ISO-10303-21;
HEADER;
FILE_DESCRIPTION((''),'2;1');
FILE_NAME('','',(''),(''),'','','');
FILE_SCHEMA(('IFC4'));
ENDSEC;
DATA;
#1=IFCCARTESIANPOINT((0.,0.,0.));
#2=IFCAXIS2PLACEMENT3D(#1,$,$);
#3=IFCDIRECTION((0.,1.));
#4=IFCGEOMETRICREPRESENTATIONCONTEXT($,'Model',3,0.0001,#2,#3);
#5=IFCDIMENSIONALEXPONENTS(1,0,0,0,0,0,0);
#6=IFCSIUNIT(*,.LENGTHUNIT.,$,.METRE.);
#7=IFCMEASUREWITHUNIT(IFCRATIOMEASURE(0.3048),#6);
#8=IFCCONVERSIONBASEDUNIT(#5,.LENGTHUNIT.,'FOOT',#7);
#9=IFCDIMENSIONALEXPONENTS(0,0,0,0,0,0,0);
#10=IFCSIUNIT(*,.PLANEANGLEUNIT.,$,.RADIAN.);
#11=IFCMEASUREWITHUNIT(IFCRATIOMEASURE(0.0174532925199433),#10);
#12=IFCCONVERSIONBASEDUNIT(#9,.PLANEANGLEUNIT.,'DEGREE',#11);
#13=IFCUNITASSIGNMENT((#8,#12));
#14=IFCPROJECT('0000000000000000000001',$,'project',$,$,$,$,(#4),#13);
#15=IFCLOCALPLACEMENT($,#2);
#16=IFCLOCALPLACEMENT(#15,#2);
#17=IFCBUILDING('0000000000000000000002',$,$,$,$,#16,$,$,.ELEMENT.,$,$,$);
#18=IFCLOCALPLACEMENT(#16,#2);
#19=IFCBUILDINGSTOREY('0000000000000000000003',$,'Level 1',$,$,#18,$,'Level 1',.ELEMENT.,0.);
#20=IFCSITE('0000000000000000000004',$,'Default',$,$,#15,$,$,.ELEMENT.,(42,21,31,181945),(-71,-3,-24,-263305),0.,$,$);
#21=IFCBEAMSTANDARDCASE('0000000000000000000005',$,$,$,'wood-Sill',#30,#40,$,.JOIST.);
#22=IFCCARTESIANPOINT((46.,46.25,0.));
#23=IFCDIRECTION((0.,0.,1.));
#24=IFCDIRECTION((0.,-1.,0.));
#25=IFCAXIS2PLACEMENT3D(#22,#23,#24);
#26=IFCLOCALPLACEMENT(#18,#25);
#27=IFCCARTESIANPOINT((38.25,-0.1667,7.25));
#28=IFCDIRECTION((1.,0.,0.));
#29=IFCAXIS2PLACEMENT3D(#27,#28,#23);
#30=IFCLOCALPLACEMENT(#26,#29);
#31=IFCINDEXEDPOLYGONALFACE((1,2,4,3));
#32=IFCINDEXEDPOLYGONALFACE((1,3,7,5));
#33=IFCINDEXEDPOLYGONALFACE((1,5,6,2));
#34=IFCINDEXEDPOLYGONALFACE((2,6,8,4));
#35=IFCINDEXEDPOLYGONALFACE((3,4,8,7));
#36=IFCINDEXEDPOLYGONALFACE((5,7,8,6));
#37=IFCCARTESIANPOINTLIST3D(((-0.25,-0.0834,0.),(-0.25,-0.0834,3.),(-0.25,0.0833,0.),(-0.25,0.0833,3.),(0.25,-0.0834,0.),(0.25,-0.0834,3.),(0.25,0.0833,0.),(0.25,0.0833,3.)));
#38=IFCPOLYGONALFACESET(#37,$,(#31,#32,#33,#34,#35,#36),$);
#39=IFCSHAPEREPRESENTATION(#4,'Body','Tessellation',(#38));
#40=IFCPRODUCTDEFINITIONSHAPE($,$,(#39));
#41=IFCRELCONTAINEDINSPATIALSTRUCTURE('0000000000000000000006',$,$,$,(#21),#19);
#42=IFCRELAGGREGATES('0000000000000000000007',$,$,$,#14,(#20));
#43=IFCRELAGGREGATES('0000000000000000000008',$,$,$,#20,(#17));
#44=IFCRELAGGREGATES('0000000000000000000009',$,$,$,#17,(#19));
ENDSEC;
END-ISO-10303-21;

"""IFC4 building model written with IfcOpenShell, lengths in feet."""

from ifc_helpers import new_model, entity, si_unit, converted_unit, direction, frame, origin, origin_with_axes, place, context, project, spatial, rectangle, extrude, element, save


model = new_model("IFC4")

# Units and contexts
model_context = context("Model", 3, precision=0.0001, world=origin(), true_north=direction((0.0, 1.0)))
ifc_project = project(units=[converted_unit("LENGTHUNIT", "FOOT", entity("IfcRatioMeasure", 0.3048), si_unit("LENGTHUNIT", "METRE"), dimensions=[1, 0, 0, 0, 0, 0, 0]), converted_unit("PLANEANGLEUNIT", "DEGREE", entity("IfcRatioMeasure", 0.0174532925199433), si_unit("PLANEANGLEUNIT", "RADIAN"), dimensions=[0, 0, 0, 0, 0, 0, 0])], contexts=[model_context])

# Site, building, storey
site_placement = place(None, origin())
site = spatial("IfcSite", under=ifc_project, at=site_placement, Name="Default", CompositionType="ELEMENT", RefLatitude=(42, 21, 31, 181945), RefLongitude=(-71, -3, -24, -263305), RefElevation=0.0)
building_placement = place(site_placement, origin())
building = spatial("IfcBuilding", under=site, at=building_placement, CompositionType="ELEMENT")
storey_placement = place(building_placement, origin())
storey = spatial("IfcBuildingStorey", under=building, at=storey_placement, Name="Level 1", LongName="Level 1", CompositionType="ELEMENT", Elevation=0.0)

# Shared definitions
placement_1 = place(storey_placement, frame((46.0, 46.25, 0.0), z_axis=(0.0, 0.0, 1.0), x_axis=(0.0, -1.0, 0.0)))

# Beam
for number, where, z_axis, x_axis in (
    (1, (38.25, -0.1667, 7.25), (1.0, 0.0, 0.0), (0.0, 0.0, 1.0)),
):
    element("IfcBeamStandardCase", number, at=place(placement_1, frame(where, z_axis=z_axis, x_axis=x_axis)), inside=storey, ObjectType="wood-Sill", PredefinedType="JOIST", context=model_context, shape_type="SweptSolid", body=[
        extrude(rectangle(XDim=0.5, YDim=0.1667), origin_with_axes(), (0.0, 0.0, 1.0), 3.0),
    ])

save(model, "model.ifc")
